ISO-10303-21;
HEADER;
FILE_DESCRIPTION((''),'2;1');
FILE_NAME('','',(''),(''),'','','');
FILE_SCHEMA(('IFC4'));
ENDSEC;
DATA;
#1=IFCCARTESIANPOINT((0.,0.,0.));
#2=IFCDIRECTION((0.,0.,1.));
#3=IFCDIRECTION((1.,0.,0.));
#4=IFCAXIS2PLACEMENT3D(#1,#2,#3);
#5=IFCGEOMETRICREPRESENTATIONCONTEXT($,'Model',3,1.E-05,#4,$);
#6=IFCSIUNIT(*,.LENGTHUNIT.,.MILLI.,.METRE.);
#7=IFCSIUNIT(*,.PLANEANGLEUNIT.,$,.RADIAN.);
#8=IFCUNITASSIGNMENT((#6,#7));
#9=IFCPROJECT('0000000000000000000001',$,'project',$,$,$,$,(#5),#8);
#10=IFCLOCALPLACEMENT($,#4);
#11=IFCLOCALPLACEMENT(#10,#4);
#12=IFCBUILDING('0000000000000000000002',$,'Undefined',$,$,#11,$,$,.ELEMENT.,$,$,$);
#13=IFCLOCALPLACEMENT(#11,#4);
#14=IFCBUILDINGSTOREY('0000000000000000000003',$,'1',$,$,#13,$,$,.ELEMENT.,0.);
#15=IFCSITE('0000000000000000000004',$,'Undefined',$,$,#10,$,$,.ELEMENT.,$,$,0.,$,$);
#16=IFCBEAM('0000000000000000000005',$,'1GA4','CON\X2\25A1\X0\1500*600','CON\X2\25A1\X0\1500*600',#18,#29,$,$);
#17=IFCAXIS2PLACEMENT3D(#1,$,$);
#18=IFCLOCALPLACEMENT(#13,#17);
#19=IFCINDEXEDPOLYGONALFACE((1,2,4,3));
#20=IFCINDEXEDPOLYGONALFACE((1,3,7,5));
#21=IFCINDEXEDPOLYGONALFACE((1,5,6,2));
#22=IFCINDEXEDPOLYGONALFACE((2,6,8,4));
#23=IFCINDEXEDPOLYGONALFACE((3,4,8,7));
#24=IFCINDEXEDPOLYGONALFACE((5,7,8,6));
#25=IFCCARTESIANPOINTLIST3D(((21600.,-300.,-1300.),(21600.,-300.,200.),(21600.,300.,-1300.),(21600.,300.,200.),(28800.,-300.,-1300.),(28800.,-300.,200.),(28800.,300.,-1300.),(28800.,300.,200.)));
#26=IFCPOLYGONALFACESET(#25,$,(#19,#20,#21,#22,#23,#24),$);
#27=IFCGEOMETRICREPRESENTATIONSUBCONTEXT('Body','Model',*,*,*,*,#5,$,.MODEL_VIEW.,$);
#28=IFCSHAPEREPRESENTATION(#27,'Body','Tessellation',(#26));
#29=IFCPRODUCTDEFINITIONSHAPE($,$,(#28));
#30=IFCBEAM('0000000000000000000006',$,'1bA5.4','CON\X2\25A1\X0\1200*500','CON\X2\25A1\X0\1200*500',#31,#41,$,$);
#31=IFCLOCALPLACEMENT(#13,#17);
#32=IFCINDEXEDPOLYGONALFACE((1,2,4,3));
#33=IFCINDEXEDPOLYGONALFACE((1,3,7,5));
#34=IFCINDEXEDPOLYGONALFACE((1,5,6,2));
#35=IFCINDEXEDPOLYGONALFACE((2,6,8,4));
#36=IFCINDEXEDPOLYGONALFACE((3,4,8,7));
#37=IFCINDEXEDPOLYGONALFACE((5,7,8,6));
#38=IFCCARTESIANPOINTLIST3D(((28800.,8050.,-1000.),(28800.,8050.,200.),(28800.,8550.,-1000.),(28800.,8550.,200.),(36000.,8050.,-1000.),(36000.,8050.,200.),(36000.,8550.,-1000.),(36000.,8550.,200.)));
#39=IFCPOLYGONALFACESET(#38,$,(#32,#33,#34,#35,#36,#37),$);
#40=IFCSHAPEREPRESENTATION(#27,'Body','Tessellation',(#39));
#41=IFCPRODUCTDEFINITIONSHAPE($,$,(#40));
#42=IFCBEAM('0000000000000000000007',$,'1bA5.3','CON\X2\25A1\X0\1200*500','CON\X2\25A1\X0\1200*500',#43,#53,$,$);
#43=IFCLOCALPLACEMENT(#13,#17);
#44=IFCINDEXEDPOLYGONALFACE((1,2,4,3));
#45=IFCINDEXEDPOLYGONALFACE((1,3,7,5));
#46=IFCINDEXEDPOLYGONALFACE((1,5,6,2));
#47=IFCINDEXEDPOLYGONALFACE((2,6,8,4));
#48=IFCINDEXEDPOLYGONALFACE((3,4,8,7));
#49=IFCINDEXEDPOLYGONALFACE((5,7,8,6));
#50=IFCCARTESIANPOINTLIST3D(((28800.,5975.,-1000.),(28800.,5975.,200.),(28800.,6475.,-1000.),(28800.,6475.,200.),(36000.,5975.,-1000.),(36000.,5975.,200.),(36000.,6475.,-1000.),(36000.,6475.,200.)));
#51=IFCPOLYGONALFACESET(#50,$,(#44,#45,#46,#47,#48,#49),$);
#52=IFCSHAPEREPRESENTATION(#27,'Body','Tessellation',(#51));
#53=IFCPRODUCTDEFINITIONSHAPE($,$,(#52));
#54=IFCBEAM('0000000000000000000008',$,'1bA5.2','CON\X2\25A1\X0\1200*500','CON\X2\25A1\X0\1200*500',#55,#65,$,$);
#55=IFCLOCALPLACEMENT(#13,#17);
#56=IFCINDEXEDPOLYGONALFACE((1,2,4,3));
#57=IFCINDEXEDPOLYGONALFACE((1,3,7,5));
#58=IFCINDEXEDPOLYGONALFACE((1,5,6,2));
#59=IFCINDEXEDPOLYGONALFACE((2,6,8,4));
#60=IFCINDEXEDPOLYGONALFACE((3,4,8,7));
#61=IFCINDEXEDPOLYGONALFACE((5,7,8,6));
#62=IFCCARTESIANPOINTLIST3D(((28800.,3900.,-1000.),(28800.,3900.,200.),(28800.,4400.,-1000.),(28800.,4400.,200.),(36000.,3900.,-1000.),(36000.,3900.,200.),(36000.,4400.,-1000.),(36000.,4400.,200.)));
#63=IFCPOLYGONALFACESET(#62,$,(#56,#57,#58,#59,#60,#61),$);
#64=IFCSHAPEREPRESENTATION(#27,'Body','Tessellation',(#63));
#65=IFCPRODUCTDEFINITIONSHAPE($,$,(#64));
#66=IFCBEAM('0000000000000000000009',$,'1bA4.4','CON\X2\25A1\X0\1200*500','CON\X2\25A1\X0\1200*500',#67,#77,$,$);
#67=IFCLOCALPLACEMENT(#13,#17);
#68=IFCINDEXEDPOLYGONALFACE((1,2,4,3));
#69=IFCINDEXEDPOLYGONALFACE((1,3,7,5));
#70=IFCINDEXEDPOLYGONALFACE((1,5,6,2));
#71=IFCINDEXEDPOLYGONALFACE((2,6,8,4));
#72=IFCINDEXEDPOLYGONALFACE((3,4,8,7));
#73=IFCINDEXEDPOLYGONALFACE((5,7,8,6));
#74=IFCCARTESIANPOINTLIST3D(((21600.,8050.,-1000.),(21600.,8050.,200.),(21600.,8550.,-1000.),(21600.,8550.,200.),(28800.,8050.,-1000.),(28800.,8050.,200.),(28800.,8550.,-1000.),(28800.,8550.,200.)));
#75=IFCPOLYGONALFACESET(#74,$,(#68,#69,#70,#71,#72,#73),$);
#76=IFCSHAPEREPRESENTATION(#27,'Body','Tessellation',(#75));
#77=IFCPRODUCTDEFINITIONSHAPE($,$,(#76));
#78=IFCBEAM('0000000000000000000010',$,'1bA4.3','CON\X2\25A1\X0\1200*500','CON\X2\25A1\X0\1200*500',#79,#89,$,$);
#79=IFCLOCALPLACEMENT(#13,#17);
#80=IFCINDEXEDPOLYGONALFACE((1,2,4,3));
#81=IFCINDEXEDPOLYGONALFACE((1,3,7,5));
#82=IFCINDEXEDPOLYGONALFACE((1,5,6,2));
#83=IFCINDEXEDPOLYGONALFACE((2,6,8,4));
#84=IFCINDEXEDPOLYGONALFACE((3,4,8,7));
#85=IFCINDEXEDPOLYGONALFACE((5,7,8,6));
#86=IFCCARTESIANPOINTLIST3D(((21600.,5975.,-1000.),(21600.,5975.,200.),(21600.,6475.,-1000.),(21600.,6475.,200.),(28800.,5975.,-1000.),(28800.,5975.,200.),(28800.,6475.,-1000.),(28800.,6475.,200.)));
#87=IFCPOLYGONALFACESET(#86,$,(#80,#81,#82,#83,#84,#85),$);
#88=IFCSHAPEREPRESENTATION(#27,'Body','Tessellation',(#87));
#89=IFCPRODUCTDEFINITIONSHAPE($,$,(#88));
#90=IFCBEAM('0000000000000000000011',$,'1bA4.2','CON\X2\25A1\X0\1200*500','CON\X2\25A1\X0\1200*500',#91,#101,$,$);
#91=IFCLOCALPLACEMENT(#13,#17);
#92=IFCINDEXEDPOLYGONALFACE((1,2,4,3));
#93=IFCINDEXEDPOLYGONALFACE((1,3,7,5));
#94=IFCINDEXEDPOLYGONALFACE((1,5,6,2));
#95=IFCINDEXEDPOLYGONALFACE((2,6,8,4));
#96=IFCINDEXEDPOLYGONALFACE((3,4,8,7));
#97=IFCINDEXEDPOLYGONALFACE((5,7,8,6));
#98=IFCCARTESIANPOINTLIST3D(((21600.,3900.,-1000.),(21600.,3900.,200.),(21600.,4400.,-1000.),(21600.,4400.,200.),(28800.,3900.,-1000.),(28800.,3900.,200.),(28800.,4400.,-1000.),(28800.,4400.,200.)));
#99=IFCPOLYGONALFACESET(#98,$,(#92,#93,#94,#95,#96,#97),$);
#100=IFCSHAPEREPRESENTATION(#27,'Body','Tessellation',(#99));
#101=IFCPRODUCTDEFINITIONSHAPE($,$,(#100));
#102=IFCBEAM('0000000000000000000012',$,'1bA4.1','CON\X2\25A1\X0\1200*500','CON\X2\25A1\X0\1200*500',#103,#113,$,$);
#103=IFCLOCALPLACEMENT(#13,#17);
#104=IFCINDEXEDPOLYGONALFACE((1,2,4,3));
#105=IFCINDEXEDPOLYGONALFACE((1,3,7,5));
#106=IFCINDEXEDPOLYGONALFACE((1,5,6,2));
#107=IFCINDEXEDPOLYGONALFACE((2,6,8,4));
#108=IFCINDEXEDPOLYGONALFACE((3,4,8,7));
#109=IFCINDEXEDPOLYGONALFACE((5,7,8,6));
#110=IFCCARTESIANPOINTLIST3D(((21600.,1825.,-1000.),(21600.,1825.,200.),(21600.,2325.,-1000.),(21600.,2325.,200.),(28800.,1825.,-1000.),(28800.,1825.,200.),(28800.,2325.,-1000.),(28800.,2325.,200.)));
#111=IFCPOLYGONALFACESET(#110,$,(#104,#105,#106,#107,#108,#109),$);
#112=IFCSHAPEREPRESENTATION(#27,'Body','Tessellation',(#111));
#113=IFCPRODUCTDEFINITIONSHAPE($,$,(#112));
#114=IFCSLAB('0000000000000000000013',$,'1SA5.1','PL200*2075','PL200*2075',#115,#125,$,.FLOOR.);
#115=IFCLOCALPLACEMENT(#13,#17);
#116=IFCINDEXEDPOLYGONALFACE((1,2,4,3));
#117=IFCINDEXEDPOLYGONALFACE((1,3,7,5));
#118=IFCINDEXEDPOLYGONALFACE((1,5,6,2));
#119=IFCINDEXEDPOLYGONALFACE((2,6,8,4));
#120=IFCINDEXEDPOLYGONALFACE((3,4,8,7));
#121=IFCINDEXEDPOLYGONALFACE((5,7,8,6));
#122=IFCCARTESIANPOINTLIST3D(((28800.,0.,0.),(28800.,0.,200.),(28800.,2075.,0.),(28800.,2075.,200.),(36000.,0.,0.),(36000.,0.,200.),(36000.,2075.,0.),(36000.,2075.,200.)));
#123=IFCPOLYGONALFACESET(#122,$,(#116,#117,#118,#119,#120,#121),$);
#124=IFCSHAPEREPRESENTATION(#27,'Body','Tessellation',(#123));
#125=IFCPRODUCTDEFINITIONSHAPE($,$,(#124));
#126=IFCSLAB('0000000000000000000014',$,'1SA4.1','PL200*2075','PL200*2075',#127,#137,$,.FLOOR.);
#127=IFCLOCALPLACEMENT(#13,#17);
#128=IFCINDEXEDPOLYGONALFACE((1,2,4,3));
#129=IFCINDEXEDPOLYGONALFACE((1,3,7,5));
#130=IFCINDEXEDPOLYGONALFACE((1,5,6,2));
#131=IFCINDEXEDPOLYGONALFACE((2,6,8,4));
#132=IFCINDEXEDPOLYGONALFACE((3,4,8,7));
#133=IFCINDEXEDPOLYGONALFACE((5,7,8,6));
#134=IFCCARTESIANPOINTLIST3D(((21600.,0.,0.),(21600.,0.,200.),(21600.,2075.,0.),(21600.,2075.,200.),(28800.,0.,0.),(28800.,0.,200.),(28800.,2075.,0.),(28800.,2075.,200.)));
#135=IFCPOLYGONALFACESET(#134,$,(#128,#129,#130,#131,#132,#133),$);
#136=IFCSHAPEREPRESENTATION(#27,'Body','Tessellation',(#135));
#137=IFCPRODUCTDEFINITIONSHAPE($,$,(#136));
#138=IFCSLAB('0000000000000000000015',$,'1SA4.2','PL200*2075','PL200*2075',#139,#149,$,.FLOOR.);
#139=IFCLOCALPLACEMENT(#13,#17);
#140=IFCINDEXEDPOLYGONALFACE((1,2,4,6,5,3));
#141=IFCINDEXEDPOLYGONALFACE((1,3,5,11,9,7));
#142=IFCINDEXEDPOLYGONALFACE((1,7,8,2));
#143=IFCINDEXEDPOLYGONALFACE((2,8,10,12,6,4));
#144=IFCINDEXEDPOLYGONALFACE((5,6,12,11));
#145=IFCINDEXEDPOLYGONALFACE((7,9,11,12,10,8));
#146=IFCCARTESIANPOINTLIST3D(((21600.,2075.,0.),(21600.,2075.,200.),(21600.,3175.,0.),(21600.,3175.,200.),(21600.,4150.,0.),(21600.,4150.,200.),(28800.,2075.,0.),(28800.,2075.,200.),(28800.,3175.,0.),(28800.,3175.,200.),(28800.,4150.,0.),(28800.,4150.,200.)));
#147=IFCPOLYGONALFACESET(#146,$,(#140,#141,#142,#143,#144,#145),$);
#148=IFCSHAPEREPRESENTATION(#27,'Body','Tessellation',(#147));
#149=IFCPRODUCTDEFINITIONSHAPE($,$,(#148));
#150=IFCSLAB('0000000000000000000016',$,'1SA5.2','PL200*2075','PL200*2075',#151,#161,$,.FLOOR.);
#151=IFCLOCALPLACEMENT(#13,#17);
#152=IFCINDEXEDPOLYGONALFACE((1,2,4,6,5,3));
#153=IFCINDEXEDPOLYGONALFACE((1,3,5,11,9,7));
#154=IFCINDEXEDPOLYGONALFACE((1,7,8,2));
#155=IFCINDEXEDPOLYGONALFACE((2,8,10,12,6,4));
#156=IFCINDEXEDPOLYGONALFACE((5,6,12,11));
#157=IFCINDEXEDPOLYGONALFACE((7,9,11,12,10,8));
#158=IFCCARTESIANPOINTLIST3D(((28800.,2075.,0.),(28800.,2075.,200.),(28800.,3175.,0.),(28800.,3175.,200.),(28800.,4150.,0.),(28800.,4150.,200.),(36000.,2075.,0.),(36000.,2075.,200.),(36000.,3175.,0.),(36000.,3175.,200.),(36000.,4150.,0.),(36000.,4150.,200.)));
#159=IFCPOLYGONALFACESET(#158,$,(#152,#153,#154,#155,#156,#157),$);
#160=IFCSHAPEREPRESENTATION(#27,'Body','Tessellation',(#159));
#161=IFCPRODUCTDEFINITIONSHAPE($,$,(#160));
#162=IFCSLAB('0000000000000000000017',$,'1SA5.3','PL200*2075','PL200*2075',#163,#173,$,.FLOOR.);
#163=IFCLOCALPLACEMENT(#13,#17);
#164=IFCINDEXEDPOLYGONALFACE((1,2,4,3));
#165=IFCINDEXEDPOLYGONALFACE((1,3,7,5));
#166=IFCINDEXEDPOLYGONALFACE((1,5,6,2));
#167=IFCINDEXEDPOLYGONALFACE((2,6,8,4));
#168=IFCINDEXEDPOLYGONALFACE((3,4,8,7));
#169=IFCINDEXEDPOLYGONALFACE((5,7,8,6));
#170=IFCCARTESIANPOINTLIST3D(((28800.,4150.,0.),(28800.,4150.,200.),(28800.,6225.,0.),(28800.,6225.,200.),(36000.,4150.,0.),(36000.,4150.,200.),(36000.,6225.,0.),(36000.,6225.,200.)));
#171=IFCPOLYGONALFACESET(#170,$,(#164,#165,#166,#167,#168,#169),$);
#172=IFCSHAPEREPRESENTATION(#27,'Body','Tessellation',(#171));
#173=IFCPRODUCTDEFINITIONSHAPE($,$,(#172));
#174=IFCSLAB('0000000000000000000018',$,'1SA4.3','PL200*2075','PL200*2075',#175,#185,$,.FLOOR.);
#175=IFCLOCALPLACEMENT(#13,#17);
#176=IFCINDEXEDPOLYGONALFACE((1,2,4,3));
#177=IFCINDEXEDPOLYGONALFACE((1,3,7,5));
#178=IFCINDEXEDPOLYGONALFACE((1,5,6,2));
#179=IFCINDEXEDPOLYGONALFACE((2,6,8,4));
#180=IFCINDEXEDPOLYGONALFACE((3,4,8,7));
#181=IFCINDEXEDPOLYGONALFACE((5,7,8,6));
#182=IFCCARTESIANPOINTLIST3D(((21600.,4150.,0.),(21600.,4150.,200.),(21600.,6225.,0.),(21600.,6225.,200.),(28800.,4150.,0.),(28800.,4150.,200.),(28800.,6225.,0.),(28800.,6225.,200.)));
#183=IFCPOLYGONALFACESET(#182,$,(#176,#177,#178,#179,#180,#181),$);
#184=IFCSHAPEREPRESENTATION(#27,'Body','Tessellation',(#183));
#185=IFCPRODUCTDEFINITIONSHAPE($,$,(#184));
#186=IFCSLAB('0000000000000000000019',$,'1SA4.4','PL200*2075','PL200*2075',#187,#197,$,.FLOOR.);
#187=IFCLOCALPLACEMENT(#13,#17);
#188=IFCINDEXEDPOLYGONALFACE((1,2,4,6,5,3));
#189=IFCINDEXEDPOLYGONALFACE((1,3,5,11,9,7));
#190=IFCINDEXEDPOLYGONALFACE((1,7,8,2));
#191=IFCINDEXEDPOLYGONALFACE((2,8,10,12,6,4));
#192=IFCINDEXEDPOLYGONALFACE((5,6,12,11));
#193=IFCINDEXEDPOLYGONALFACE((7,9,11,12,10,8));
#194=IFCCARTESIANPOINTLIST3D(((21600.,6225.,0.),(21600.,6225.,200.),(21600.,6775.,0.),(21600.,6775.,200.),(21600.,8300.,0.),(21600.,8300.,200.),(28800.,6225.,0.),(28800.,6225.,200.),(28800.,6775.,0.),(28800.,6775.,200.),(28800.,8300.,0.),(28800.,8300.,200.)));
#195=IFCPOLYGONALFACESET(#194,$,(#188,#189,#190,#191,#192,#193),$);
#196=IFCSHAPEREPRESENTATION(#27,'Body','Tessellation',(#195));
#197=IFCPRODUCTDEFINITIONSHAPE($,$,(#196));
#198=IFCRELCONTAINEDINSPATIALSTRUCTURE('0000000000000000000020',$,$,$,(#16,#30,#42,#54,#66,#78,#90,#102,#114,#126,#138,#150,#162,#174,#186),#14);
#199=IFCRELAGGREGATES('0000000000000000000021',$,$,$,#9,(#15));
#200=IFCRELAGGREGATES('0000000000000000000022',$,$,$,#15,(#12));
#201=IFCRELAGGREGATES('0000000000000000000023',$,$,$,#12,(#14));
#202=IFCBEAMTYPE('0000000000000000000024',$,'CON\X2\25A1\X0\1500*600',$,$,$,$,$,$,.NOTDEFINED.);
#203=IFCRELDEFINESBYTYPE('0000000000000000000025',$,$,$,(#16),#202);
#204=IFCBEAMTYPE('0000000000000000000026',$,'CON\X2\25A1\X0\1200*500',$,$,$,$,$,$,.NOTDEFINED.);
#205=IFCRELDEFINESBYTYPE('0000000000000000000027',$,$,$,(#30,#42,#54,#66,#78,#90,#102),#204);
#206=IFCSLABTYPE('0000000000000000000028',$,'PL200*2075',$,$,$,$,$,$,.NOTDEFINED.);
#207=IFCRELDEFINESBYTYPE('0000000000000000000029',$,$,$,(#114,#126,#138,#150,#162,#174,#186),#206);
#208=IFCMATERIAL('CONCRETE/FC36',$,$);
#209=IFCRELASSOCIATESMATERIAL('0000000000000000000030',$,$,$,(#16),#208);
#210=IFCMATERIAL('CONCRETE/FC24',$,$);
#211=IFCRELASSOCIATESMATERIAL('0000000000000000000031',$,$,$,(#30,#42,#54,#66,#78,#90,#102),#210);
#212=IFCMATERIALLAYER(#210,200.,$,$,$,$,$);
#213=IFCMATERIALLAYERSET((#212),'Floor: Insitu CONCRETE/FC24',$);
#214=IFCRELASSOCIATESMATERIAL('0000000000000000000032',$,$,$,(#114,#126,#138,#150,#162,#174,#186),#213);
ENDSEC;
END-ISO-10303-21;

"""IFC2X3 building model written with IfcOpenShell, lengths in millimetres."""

from ifc_helpers import new_model, si_unit, frame, origin_with_axes, origin_2d_with_axis, place, context, subcontext, project, spatial, polyline, rectangle, outline, extrude, material, layer, layer_set, layer_usage, type_object, element, save


model = new_model("IFC2X3")

# Units and contexts
model_context = context("Model", 3, precision=1e-05, world=origin_with_axes())
body_context = subcontext(model_context, "Body", "Model", "MODEL_VIEW")
ifc_project = project(units=[si_unit("LENGTHUNIT", "METRE", prefix="MILLI"), si_unit("PLANEANGLEUNIT", "RADIAN")], contexts=[model_context])

# Site, building, storey
site_placement = place(None, origin_with_axes())
site = spatial("IfcSite", under=ifc_project, at=site_placement, Name="Undefined", CompositionType="ELEMENT", RefElevation=0.0)
building_placement = place(site_placement, origin_with_axes())
building = spatial("IfcBuilding", under=site, at=building_placement, Name="Undefined", CompositionType="ELEMENT")
storey_placement = place(building_placement, origin_with_axes())
storey = spatial("IfcBuildingStorey", under=building, at=storey_placement, Name="1", CompositionType="ELEMENT", Elevation=0.0)

# Shared definitions
ifc_material_1 = material(Name="CONCRETE/FC24")

# Beams
ifc_material_2 = material(Name="CONCRETE/FC36")
beam_type_1 = type_object("IfcBeamType", Name="CON□1500*600", PredefinedType="NOTDEFINED")
beam_1_placement = place(storey_placement, frame((21600.0, 0.0, -550.0), z_axis=(0.0, 0.0, 1.0), x_axis=(1.0, 0.0, 0.0)))
element("IfcBeam", 1, at=beam_1_placement, inside=storey, type_object=beam_type_1, material=ifc_material_2, Name="1GA4", Description="CON□1500*600", ObjectType="CON□1500*600", context=body_context, shape_type="SweptSolid", body=[
    extrude(rectangle(XDim=600.0, YDim=1500.0, at=origin_2d_with_axis()), frame((7200.0, 0.0, 0.0), z_axis=(-1.0, 0.0, 0.0), x_axis=(0.0, -1.0, 0.0)), (0.0, 0.0, 1.0), 7200.0),
])
beam_type_2 = type_object("IfcBeamType", Name="CON□1200*500", PredefinedType="NOTDEFINED")
for number, where, z_axis, x_axis, name in (
    (2, (28800.0, 8300.0, -400.0), (0.0, 0.0, 1.0), (1.0, 0.0, 0.0), "1bA5.4"),
    (3, (28800.0, 6225.0, -400.0), (0.0, 0.0, 1.0), (1.0, 0.0, 0.0), "1bA5.3"),
    (4, (28800.0, 4150.0, -400.0), (0.0, 0.0, 1.0), (1.0, 0.0, 0.0), "1bA5.2"),
    (5, (21600.0, 8300.0, -400.0), (0.0, 0.0, 1.0), (1.0, 0.0, 0.0), "1bA4.4"),
    (6, (21600.0, 6225.0, -400.0), (0.0, 0.0, 1.0), (1.0, 0.0, 0.0), "1bA4.3"),
    (7, (21600.0, 4150.0, -400.0), (0.0, 0.0, 1.0), (1.0, 0.0, 0.0), "1bA4.2"),
    (8, (21600.0, 2075.0, -400.0), (0.0, 0.0, 1.0), (1.0, 0.0, 0.0), "1bA4.1"),
):
    element("IfcBeam", number, at=place(storey_placement, frame(where, z_axis=z_axis, x_axis=x_axis)), inside=storey, type_object=beam_type_2, material=ifc_material_1, Name=name, Description="CON□1200*500", ObjectType="CON□1200*500", context=body_context, shape_type="SweptSolid", body=[
        extrude(rectangle(XDim=500.0, YDim=1200.0, at=origin_2d_with_axis()), frame((7200.0, 0.0, 0.0), z_axis=(-1.0, 0.0, 0.0), x_axis=(0.0, -1.0, 0.0)), (0.0, 0.0, 1.0), 7200.0),
    ])

# Slabs
ifc_layer = layer(ifc_material_1, 200.0)
ifc_layer_set = layer_set([ifc_layer], Name="Floor: Insitu CONCRETE/FC24")
ifc_layer_usage_1 = layer_usage(ifc_layer_set, "AXIS3", "POSITIVE", -100.0)
slab_type = type_object("IfcSlabType", Name="PL200*2075", PredefinedType="NOTDEFINED")
slab_1_placement = place(storey_placement, frame((28800.0, 0.0, 100.0), z_axis=(0.0, 0.0, 1.0), x_axis=(1.0, 0.0, 0.0)))
element("IfcSlab", 9, at=slab_1_placement, inside=storey, type_object=slab_type, material=ifc_layer_usage_1, Name="1SA5.1", Description="PL200*2075", ObjectType="PL200*2075", PredefinedType="FLOOR", context=body_context, shape_type="SweptSolid", body=[
    extrude(outline(polyline([(0.0, 0.0), (7200.0, 0.0), (7200.0, 2075.0), (0.0, 2075.0), (0.0, 0.0)])), frame((0.0, 0.0, -100.0), z_axis=(0.0, 0.0, 1.0), x_axis=(1.0, 0.0, 0.0)), (0.0, 0.0, 1.0), 200.0),
])
ifc_layer_usage_2 = layer_usage(ifc_layer_set, "AXIS3", "POSITIVE", -100.0)
slab_2_placement = place(storey_placement, frame((21600.0, 0.0, 100.0), z_axis=(0.0, 0.0, 1.0), x_axis=(1.0, 0.0, 0.0)))
element("IfcSlab", 10, at=slab_2_placement, inside=storey, type_object=slab_type, material=ifc_layer_usage_2, Name="1SA4.1", Description="PL200*2075", ObjectType="PL200*2075", PredefinedType="FLOOR", context=body_context, shape_type="SweptSolid", body=[
    extrude(outline(polyline([(0.0, 0.0), (7200.0, 0.0), (7200.0, 2075.0), (0.0, 2075.0), (0.0, 0.0)])), frame((0.0, 0.0, -100.0), z_axis=(0.0, 0.0, 1.0), x_axis=(1.0, 0.0, 0.0)), (0.0, 0.0, 1.0), 200.0),
])
ifc_layer_usage_3 = layer_usage(ifc_layer_set, "AXIS3", "POSITIVE", -100.0)
slab_3_placement = place(storey_placement, frame((21600.0, 2075.0, 100.0), z_axis=(0.0, 0.0, 1.0), x_axis=(1.0, 0.0, 0.0)))
element("IfcSlab", 11, at=slab_3_placement, inside=storey, type_object=slab_type, material=ifc_layer_usage_3, Name="1SA4.2", Description="PL200*2075", ObjectType="PL200*2075", PredefinedType="FLOOR", context=body_context, shape_type="SweptSolid", body=[
    extrude(outline(polyline([(0.0, 0.0), (7200.0, 0.0), (7200.0, 1100.0), (7200.0, 2075.0), (0.0, 2075.0), (0.0, 1100.0), (0.0, 0.0)])), frame((0.0, 0.0, -100.0), z_axis=(0.0, 0.0, 1.0), x_axis=(1.0, 0.0, 0.0)), (0.0, 0.0, 1.0), 200.0),
])
ifc_layer_usage_4 = layer_usage(ifc_layer_set, "AXIS3", "POSITIVE", -100.0)
slab_4_placement = place(storey_placement, frame((28800.0, 2075.0, 100.0), z_axis=(0.0, 0.0, 1.0), x_axis=(1.0, 0.0, 0.0)))
element("IfcSlab", 12, at=slab_4_placement, inside=storey, type_object=slab_type, material=ifc_layer_usage_4, Name="1SA5.2", Description="PL200*2075", ObjectType="PL200*2075", PredefinedType="FLOOR", context=body_context, shape_type="SweptSolid", body=[
    extrude(outline(polyline([(0.0, 0.0), (7200.0, 0.0), (7200.0, 1100.0), (7200.0, 2075.0), (0.0, 2075.0), (0.0, 1100.0), (0.0, 0.0)])), frame((0.0, 0.0, -100.0), z_axis=(0.0, 0.0, 1.0), x_axis=(1.0, 0.0, 0.0)), (0.0, 0.0, 1.0), 200.0),
])
ifc_layer_usage_5 = layer_usage(ifc_layer_set, "AXIS3", "POSITIVE", -100.0)
slab_5_placement = place(storey_placement, frame((28800.0, 4150.0, 100.0), z_axis=(0.0, 0.0, 1.0), x_axis=(1.0, 0.0, 0.0)))
element("IfcSlab", 13, at=slab_5_placement, inside=storey, type_object=slab_type, material=ifc_layer_usage_5, Name="1SA5.3", Description="PL200*2075", ObjectType="PL200*2075", PredefinedType="FLOOR", context=body_context, shape_type="SweptSolid", body=[
    extrude(outline(polyline([(0.0, 0.0), (7200.0, 0.0), (7200.0, 2075.0), (0.0, 2075.0), (0.0, 0.0)])), frame((0.0, 0.0, -100.0), z_axis=(0.0, 0.0, 1.0), x_axis=(1.0, 0.0, 0.0)), (0.0, 0.0, 1.0), 200.0),
])
ifc_layer_usage_6 = layer_usage(ifc_layer_set, "AXIS3", "POSITIVE", -100.0)
slab_6_placement = place(storey_placement, frame((21600.0, 4150.0, 100.0), z_axis=(0.0, 0.0, 1.0), x_axis=(1.0, 0.0, 0.0)))
element("IfcSlab", 14, at=slab_6_placement, inside=storey, type_object=slab_type, material=ifc_layer_usage_6, Name="1SA4.3", Description="PL200*2075", ObjectType="PL200*2075", PredefinedType="FLOOR", context=body_context, shape_type="SweptSolid", body=[
    extrude(outline(polyline([(0.0, 0.0), (7200.0, 0.0), (7200.0, 2075.0), (0.0, 2075.0), (0.0, 0.0)])), frame((0.0, 0.0, -100.0), z_axis=(0.0, 0.0, 1.0), x_axis=(1.0, 0.0, 0.0)), (0.0, 0.0, 1.0), 200.0),
])
ifc_layer_usage_7 = layer_usage(ifc_layer_set, "AXIS3", "POSITIVE", -100.0)
slab_7_placement = place(storey_placement, frame((21600.0, 6225.0, 100.0), z_axis=(0.0, 0.0, 1.0), x_axis=(1.0, 0.0, 0.0)))
element("IfcSlab", 15, at=slab_7_placement, inside=storey, type_object=slab_type, material=ifc_layer_usage_7, Name="1SA4.4", Description="PL200*2075", ObjectType="PL200*2075", PredefinedType="FLOOR", context=body_context, shape_type="SweptSolid", body=[
    extrude(outline(polyline([(0.0, 0.0), (7200.0, 0.0), (7200.0, 550.0), (7200.0, 2075.0), (0.0, 2075.0), (0.0, 550.0), (0.0, 0.0)])), frame((0.0, 0.0, -100.0), z_axis=(0.0, 0.0, 1.0), x_axis=(1.0, 0.0, 0.0)), (0.0, 0.0, 1.0), 200.0),
])

save(model, "model.ifc")
